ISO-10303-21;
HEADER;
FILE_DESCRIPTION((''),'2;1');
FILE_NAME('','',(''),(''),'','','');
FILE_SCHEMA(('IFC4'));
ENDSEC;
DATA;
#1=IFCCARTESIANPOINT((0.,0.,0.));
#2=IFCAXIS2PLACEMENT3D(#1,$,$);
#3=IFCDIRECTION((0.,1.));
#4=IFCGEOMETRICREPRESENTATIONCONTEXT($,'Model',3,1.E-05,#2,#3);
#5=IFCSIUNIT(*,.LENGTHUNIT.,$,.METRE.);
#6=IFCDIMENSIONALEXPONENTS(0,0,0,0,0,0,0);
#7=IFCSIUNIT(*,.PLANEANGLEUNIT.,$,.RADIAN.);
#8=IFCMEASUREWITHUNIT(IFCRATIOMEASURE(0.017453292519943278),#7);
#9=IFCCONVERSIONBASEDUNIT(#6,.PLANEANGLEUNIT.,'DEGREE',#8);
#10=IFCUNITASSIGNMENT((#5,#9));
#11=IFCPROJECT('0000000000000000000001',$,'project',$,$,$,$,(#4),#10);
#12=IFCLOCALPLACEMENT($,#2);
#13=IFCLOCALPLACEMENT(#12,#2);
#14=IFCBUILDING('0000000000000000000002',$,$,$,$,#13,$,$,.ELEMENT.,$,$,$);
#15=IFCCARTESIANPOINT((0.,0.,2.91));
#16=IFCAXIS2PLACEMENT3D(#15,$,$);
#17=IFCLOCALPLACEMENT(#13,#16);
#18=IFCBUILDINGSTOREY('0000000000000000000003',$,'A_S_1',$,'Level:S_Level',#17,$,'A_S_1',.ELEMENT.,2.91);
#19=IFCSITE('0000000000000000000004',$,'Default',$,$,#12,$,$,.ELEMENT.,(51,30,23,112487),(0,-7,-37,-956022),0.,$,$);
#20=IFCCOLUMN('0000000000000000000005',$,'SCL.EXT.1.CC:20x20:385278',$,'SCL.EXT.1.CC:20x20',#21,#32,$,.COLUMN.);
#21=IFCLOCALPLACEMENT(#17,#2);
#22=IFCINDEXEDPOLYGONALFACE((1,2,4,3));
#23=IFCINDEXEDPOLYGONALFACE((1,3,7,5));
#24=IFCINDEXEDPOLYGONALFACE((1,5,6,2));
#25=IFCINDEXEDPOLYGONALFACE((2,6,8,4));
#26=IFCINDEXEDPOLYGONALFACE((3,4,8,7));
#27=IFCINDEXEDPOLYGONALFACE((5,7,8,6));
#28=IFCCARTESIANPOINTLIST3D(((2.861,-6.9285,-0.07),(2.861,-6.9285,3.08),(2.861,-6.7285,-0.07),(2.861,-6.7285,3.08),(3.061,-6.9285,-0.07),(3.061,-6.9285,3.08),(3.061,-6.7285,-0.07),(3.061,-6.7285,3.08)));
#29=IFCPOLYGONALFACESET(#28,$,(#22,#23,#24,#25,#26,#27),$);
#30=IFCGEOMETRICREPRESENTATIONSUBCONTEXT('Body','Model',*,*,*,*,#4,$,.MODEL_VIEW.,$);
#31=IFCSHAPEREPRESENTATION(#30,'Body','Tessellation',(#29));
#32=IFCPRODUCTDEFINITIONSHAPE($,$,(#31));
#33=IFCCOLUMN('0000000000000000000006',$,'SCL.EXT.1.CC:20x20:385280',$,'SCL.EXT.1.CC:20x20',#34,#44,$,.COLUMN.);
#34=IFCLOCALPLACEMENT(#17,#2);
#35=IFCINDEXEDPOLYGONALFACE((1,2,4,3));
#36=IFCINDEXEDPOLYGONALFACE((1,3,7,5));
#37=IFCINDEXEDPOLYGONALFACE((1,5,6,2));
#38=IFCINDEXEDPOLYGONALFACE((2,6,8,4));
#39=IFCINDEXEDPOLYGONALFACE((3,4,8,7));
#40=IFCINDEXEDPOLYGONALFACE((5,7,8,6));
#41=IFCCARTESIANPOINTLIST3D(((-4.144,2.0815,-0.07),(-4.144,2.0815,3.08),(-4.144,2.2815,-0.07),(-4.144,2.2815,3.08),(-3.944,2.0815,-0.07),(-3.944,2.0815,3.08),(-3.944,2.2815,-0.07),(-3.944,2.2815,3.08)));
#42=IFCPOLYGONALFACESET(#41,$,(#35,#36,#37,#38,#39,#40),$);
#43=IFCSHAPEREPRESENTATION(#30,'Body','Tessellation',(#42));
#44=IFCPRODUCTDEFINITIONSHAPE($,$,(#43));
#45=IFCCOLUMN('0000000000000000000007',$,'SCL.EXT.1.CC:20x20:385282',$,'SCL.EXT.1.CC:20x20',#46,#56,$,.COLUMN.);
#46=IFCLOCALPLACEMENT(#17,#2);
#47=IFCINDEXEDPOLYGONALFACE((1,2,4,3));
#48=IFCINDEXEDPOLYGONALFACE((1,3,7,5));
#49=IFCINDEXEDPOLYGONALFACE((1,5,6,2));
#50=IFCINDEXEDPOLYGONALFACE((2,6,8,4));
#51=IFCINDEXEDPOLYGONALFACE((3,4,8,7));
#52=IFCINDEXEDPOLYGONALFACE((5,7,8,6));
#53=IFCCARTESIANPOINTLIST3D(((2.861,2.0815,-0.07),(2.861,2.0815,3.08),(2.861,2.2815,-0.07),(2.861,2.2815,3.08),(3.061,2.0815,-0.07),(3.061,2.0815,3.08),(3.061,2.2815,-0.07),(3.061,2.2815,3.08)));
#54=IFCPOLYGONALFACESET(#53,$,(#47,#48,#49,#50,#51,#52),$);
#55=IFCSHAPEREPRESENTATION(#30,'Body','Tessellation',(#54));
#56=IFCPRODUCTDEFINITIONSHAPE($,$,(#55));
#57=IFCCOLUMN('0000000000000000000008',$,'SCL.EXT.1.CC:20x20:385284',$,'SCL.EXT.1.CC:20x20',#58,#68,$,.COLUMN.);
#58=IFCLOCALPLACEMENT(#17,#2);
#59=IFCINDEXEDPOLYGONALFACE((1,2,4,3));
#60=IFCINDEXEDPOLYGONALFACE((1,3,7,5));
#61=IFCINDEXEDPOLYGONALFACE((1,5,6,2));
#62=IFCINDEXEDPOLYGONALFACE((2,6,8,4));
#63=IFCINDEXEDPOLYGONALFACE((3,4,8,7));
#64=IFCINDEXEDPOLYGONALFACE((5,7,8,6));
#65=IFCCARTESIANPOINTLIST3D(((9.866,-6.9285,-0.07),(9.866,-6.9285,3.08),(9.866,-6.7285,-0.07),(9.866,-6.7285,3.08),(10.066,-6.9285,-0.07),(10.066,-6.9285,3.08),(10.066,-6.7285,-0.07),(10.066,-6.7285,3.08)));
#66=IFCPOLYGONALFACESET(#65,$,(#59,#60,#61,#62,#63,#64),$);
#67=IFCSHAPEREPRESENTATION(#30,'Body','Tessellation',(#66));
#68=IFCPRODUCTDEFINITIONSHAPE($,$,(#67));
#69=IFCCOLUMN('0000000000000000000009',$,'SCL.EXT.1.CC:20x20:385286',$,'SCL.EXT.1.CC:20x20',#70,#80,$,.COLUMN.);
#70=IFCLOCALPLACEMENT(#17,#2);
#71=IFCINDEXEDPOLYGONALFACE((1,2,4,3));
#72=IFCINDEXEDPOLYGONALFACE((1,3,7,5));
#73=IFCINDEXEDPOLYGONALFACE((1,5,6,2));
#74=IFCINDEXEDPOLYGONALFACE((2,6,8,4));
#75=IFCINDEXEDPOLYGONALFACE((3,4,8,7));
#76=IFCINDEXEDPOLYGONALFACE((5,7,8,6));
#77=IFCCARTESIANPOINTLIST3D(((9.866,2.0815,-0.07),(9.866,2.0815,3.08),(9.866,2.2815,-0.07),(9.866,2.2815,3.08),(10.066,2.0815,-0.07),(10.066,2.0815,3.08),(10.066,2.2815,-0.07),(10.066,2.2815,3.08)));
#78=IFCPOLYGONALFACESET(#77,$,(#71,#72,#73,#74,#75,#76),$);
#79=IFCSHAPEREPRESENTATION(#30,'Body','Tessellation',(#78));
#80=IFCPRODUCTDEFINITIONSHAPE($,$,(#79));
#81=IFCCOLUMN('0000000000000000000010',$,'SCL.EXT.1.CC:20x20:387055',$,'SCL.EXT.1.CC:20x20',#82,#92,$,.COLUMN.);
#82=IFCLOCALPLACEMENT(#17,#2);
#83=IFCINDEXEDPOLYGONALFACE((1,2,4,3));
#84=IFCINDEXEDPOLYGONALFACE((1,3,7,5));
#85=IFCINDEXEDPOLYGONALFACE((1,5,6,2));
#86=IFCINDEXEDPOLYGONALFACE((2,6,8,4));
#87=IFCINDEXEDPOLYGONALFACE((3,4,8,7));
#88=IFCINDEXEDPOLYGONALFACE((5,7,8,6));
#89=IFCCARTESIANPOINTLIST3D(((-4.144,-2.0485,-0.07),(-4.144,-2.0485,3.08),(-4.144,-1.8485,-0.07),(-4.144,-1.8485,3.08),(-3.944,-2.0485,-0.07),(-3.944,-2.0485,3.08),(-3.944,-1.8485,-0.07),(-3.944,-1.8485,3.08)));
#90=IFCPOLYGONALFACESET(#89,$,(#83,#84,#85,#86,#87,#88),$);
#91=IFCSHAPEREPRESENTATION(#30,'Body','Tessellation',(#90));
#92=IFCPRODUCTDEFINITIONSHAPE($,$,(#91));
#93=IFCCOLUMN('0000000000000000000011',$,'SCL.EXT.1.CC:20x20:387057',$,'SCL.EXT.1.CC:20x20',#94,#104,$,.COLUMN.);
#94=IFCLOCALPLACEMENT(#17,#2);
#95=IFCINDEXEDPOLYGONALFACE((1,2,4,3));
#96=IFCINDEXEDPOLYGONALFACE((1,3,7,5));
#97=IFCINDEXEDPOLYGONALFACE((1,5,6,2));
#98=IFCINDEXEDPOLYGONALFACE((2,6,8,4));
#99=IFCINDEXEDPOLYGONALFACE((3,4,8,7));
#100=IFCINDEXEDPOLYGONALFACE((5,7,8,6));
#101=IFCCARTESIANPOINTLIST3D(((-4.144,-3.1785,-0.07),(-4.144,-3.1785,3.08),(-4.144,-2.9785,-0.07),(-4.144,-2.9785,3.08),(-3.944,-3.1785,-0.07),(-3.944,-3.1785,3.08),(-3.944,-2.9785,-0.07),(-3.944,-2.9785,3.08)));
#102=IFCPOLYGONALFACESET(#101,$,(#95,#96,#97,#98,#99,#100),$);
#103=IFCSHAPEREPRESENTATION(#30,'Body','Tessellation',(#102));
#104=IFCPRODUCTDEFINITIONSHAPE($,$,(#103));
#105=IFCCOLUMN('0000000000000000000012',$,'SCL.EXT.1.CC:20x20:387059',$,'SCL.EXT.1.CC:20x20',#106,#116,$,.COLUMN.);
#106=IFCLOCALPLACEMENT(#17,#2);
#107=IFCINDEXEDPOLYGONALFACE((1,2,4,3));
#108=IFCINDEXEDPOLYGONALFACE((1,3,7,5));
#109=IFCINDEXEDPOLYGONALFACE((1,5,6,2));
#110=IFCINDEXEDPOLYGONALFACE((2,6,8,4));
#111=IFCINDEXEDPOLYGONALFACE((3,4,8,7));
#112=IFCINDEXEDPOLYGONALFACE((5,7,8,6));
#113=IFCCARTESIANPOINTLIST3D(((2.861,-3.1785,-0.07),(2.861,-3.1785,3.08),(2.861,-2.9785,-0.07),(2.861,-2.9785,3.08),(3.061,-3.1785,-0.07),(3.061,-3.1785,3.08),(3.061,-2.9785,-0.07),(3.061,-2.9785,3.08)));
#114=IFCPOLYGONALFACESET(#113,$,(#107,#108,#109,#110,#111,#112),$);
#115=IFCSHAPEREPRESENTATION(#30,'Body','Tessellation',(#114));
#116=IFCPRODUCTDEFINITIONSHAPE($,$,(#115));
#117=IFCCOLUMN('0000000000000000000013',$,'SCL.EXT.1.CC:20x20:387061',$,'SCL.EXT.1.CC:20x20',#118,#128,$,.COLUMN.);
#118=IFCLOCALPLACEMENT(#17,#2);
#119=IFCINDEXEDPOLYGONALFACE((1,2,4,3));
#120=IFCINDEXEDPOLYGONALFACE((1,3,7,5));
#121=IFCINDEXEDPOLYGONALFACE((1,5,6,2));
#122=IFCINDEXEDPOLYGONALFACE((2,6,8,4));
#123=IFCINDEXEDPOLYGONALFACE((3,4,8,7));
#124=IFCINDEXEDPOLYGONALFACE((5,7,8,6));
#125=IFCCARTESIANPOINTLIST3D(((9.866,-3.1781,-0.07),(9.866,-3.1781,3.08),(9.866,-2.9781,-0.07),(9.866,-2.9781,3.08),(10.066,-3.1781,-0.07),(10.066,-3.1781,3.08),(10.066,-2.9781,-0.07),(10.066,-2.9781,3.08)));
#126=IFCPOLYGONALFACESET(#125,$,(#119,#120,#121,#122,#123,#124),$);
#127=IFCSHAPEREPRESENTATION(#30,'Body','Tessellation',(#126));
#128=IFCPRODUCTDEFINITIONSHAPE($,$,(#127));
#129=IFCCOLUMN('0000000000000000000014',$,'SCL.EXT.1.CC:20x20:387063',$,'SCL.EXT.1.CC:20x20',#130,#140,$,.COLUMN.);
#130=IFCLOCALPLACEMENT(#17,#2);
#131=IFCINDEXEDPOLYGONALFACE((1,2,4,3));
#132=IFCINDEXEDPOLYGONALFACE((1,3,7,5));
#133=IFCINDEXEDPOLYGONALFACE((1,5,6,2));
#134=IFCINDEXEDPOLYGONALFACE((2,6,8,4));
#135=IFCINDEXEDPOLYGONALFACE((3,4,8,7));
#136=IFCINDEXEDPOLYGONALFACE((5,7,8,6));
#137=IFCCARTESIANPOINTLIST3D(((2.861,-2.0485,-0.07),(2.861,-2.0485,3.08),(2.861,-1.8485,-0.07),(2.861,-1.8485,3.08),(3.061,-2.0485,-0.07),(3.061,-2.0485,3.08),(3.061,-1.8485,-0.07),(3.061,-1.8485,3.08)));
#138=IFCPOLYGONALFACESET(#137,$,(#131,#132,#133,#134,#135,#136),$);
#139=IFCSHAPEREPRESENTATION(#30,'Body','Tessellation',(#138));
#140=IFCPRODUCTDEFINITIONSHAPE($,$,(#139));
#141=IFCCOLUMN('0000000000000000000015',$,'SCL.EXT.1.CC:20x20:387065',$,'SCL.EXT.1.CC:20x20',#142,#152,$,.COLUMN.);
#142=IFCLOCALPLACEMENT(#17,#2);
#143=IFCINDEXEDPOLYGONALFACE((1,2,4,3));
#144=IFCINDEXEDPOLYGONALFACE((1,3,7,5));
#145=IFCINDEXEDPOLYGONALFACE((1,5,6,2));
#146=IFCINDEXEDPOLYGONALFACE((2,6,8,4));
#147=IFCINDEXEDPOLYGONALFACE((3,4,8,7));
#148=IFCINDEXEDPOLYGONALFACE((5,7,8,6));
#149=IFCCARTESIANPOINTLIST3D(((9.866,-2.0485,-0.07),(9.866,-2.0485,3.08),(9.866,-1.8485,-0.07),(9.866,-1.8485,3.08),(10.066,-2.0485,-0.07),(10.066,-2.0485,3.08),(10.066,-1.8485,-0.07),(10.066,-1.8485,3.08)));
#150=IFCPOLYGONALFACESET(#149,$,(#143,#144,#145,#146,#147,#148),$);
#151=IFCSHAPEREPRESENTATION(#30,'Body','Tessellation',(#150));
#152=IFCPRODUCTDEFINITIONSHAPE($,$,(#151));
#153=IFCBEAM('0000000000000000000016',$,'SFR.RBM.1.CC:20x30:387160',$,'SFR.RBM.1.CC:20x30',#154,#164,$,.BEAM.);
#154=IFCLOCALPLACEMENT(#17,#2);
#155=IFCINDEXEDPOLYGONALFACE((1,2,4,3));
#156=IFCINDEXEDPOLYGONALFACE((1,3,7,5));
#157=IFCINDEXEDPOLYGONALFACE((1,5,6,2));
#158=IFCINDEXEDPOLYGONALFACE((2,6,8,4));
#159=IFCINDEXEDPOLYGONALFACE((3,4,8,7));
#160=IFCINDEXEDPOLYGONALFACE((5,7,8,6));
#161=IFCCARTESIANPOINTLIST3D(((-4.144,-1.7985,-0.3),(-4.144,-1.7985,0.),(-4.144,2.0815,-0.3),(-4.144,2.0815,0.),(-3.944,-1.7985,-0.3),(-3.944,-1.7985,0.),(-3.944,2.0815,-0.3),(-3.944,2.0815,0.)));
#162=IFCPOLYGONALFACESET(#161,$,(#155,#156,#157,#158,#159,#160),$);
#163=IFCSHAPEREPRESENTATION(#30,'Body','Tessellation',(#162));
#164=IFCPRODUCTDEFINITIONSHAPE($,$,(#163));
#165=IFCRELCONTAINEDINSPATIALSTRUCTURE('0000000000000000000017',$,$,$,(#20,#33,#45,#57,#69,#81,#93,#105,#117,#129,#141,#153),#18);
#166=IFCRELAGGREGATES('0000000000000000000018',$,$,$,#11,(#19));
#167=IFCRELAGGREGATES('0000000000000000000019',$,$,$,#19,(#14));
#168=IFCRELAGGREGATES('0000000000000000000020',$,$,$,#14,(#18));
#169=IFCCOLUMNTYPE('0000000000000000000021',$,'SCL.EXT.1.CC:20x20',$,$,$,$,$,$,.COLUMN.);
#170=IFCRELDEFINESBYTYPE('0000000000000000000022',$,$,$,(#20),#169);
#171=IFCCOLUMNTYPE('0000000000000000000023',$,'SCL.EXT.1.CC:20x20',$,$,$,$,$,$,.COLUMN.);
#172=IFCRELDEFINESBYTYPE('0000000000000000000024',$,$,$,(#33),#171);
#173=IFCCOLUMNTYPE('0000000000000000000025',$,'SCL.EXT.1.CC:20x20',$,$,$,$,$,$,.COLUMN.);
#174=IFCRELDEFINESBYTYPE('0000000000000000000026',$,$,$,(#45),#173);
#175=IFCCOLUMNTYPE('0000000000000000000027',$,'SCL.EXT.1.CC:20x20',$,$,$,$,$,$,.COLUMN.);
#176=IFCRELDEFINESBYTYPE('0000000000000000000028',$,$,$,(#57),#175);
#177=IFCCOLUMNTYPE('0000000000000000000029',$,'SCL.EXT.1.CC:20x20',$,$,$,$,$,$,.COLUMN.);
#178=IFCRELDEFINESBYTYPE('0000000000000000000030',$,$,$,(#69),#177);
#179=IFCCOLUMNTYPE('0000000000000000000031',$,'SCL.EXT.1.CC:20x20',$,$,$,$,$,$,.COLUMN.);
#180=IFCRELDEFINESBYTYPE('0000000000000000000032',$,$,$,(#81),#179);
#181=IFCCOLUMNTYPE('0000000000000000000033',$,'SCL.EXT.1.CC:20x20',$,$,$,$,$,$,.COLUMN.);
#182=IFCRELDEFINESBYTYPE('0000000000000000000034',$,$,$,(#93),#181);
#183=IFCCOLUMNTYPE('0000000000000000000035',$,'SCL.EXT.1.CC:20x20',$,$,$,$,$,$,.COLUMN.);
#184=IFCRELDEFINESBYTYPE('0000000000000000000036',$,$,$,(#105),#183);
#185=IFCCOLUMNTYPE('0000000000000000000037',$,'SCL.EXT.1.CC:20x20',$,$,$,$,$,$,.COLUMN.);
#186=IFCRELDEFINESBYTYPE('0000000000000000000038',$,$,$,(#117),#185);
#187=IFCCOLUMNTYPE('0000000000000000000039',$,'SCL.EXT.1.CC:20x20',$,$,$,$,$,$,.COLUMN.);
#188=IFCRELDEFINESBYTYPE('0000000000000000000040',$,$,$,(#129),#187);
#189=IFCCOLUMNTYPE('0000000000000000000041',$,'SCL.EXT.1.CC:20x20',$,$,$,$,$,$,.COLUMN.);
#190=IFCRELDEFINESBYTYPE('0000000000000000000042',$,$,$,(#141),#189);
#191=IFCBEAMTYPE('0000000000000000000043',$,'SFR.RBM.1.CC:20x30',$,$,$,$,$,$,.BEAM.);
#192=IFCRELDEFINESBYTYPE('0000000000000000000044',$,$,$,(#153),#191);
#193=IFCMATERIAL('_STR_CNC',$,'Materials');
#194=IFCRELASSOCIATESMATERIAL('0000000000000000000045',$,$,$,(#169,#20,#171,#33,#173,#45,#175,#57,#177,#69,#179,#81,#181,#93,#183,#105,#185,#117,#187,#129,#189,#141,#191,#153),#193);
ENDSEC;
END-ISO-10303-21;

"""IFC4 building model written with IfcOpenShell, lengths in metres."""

from ifc_helpers import new_model, entity, si_unit, converted_unit, direction, frame, origin, place, context, subcontext, project, spatial, indexed_curve, outline, extrude, source, transform, mapped, material, type_object, type_shapes, element, save


model = new_model("IFC4")

# Units and contexts
model_context = context("Model", 3, precision=1e-05, world=origin(), true_north=direction((0.0, 1.0)))
body_context = subcontext(model_context, "Body", "Model", "MODEL_VIEW")
ifc_project = project(units=[si_unit("LENGTHUNIT", "METRE"), converted_unit("PLANEANGLEUNIT", "DEGREE", entity("IfcRatioMeasure", 0.017453292519943278), si_unit("PLANEANGLEUNIT", "RADIAN"), dimensions=[0, 0, 0, 0, 0, 0, 0])], contexts=[model_context])

# Site, building, storey
site_placement = place(None, origin())
site = spatial("IfcSite", under=ifc_project, at=site_placement, Name="Default", CompositionType="ELEMENT", RefLatitude=(51, 30, 23, 112487), RefLongitude=(0, -7, -37, -956022), RefElevation=0.0)
building_placement = place(site_placement, origin())
building = spatial("IfcBuilding", under=site, at=building_placement, CompositionType="ELEMENT")
storey_placement = place(building_placement, frame((0.0, 0.0, 2.91)))
storey = spatial("IfcBuildingStorey", under=building, at=storey_placement, Name="A_S_1", ObjectType="Level:S_Level", LongName="A_S_1", CompositionType="ELEMENT", Elevation=2.91)

# Columns
ifc_material_1 = material(Name="_STR_CNC", Category="Materials")
column_type_1 = type_object("IfcColumnType", Name="SCL.EXT.1.CC:20x20", PredefinedType="COLUMN", material=ifc_material_1)
shared_shape_1 = source(origin(), body_context, "Body", "SweptSolid", [
    extrude(outline(indexed_curve([(-0.1, -0.1), (0.1, -0.1), (0.1, 0.1), (-0.1, 0.1), (-0.1, -0.1)], self_intersect=False)), frame((2.961, -6.8285, 2.84), z_axis=(0.0, 0.0, 1.0), x_axis=(0.0, -1.0, 0.0)), (0.0, 0.0, 1.0), 3.15),
])
type_shapes(column_type_1, [shared_shape_1])
column_1_placement = place(storey_placement, frame((0.0, 0.0, -2.91)))
element("IfcColumn", 1, at=column_1_placement, inside=storey, type_object=column_type_1, material=ifc_material_1, Name="SCL.EXT.1.CC:20x20:385278", ObjectType="SCL.EXT.1.CC:20x20", PredefinedType="COLUMN", context=body_context, shape_type="MappedRepresentation", body=[
    mapped(shared_shape_1, transform((0.0, 0.0, 0.0), scale=1.0)),
])
column_type_2 = type_object("IfcColumnType", Name="SCL.EXT.1.CC:20x20", PredefinedType="COLUMN", material=ifc_material_1)
shared_shape_2 = source(origin(), body_context, "Body", "SweptSolid", [
    extrude(outline(indexed_curve([(-0.1, -0.1), (0.1, -0.1), (0.1, 0.1), (-0.1, 0.1), (-0.1, -0.1)], self_intersect=False)), frame((-4.044, 2.1815, 2.84), z_axis=(0.0, 0.0, 1.0), x_axis=(0.0, -1.0, 0.0)), (0.0, 0.0, 1.0), 3.15),
])
type_shapes(column_type_2, [shared_shape_2])
column_2_placement = place(storey_placement, frame((0.0, 0.0, -2.91)))
element("IfcColumn", 2, at=column_2_placement, inside=storey, type_object=column_type_2, material=ifc_material_1, Name="SCL.EXT.1.CC:20x20:385280", ObjectType="SCL.EXT.1.CC:20x20", PredefinedType="COLUMN", context=body_context, shape_type="MappedRepresentation", body=[
    mapped(shared_shape_2, transform((0.0, 0.0, 0.0), scale=1.0)),
])
column_type_3 = type_object("IfcColumnType", Name="SCL.EXT.1.CC:20x20", PredefinedType="COLUMN", material=ifc_material_1)
shared_shape_3 = source(origin(), body_context, "Body", "SweptSolid", [
    extrude(outline(indexed_curve([(-0.1, -0.1), (0.1, -0.1), (0.1, 0.1), (-0.1, 0.1), (-0.1, -0.1)], self_intersect=False)), frame((2.961, 2.1815, 2.84), z_axis=(0.0, 0.0, 1.0), x_axis=(0.0, -1.0, 0.0)), (0.0, 0.0, 1.0), 3.15),
])
type_shapes(column_type_3, [shared_shape_3])
column_3_placement = place(storey_placement, frame((0.0, 0.0, -2.91)))
element("IfcColumn", 3, at=column_3_placement, inside=storey, type_object=column_type_3, material=ifc_material_1, Name="SCL.EXT.1.CC:20x20:385282", ObjectType="SCL.EXT.1.CC:20x20", PredefinedType="COLUMN", context=body_context, shape_type="MappedRepresentation", body=[
    mapped(shared_shape_3, transform((0.0, 0.0, 0.0), scale=1.0)),
])
column_type_4 = type_object("IfcColumnType", Name="SCL.EXT.1.CC:20x20", PredefinedType="COLUMN", material=ifc_material_1)
shared_shape_4 = source(origin(), body_context, "Body", "SweptSolid", [
    extrude(outline(indexed_curve([(-0.1, -0.1), (0.1, -0.1), (0.1, 0.1), (-0.1, 0.1), (-0.1, -0.1)], self_intersect=False)), frame((9.966, -6.8285, 2.84), z_axis=(0.0, 0.0, 1.0), x_axis=(0.0, -1.0, 0.0)), (0.0, 0.0, 1.0), 3.15),
])
type_shapes(column_type_4, [shared_shape_4])
column_4_placement = place(storey_placement, frame((0.0, 0.0, -2.91)))
element("IfcColumn", 4, at=column_4_placement, inside=storey, type_object=column_type_4, material=ifc_material_1, Name="SCL.EXT.1.CC:20x20:385284", ObjectType="SCL.EXT.1.CC:20x20", PredefinedType="COLUMN", context=body_context, shape_type="MappedRepresentation", body=[
    mapped(shared_shape_4, transform((0.0, 0.0, 0.0), scale=1.0)),
])
column_type_5 = type_object("IfcColumnType", Name="SCL.EXT.1.CC:20x20", PredefinedType="COLUMN", material=ifc_material_1)
shared_shape_5 = source(origin(), body_context, "Body", "SweptSolid", [
    extrude(outline(indexed_curve([(-0.1, -0.1), (0.1, -0.1), (0.1, 0.1), (-0.1, 0.1), (-0.1, -0.1)], self_intersect=False)), frame((9.966, 2.1815, 2.84), z_axis=(0.0, 0.0, 1.0), x_axis=(0.0, -1.0, 0.0)), (0.0, 0.0, 1.0), 3.15),
])
type_shapes(column_type_5, [shared_shape_5])
column_5_placement = place(storey_placement, frame((0.0, 0.0, -2.91)))
element("IfcColumn", 5, at=column_5_placement, inside=storey, type_object=column_type_5, material=ifc_material_1, Name="SCL.EXT.1.CC:20x20:385286", ObjectType="SCL.EXT.1.CC:20x20", PredefinedType="COLUMN", context=body_context, shape_type="MappedRepresentation", body=[
    mapped(shared_shape_5, transform((0.0, 0.0, 0.0), scale=1.0)),
])
column_type_6 = type_object("IfcColumnType", Name="SCL.EXT.1.CC:20x20", PredefinedType="COLUMN", material=ifc_material_1)
shared_shape_6 = source(origin(), body_context, "Body", "SweptSolid", [
    extrude(outline(indexed_curve([(-0.1, -0.1), (0.1, -0.1), (0.1, 0.1), (-0.1, 0.1), (-0.1, -0.1)], self_intersect=False)), frame((-4.044, -1.9485, 2.84), z_axis=(0.0, 0.0, 1.0), x_axis=(0.0, -1.0, 0.0)), (0.0, 0.0, 1.0), 3.15),
])
type_shapes(column_type_6, [shared_shape_6])
column_6_placement = place(storey_placement, frame((0.0, 0.0, -2.91)))
element("IfcColumn", 6, at=column_6_placement, inside=storey, type_object=column_type_6, material=ifc_material_1, Name="SCL.EXT.1.CC:20x20:387055", ObjectType="SCL.EXT.1.CC:20x20", PredefinedType="COLUMN", context=body_context, shape_type="MappedRepresentation", body=[
    mapped(shared_shape_6, transform((0.0, 0.0, 0.0), scale=1.0)),
])
column_type_7 = type_object("IfcColumnType", Name="SCL.EXT.1.CC:20x20", PredefinedType="COLUMN", material=ifc_material_1)
shared_shape_7 = source(origin(), body_context, "Body", "SweptSolid", [
    extrude(outline(indexed_curve([(-0.1, -0.1), (0.1, -0.1), (0.1, 0.1), (-0.1, 0.1), (-0.1, -0.1)], self_intersect=False)), frame((-4.044, -3.0785, 2.84), z_axis=(0.0, 0.0, 1.0), x_axis=(0.0, -1.0, 0.0)), (0.0, 0.0, 1.0), 3.15),
])
type_shapes(column_type_7, [shared_shape_7])
column_7_placement = place(storey_placement, frame((0.0, 0.0, -2.91)))
element("IfcColumn", 7, at=column_7_placement, inside=storey, type_object=column_type_7, material=ifc_material_1, Name="SCL.EXT.1.CC:20x20:387057", ObjectType="SCL.EXT.1.CC:20x20", PredefinedType="COLUMN", context=body_context, shape_type="MappedRepresentation", body=[
    mapped(shared_shape_7, transform((0.0, 0.0, 0.0), scale=1.0)),
])
column_type_8 = type_object("IfcColumnType", Name="SCL.EXT.1.CC:20x20", PredefinedType="COLUMN", material=ifc_material_1)
shared_shape_8 = source(origin(), body_context, "Body", "SweptSolid", [
    extrude(outline(indexed_curve([(-0.1, -0.1), (0.1, -0.1), (0.1, 0.1), (-0.1, 0.1), (-0.1, -0.1)], self_intersect=False)), frame((2.961, -3.0785, 2.84), z_axis=(0.0, 0.0, 1.0), x_axis=(0.0, -1.0, 0.0)), (0.0, 0.0, 1.0), 3.15),
])
type_shapes(column_type_8, [shared_shape_8])
column_8_placement = place(storey_placement, frame((0.0, 0.0, -2.91)))
element("IfcColumn", 8, at=column_8_placement, inside=storey, type_object=column_type_8, material=ifc_material_1, Name="SCL.EXT.1.CC:20x20:387059", ObjectType="SCL.EXT.1.CC:20x20", PredefinedType="COLUMN", context=body_context, shape_type="MappedRepresentation", body=[
    mapped(shared_shape_8, transform((0.0, 0.0, 0.0), scale=1.0)),
])
column_type_9 = type_object("IfcColumnType", Name="SCL.EXT.1.CC:20x20", PredefinedType="COLUMN", material=ifc_material_1)
shared_shape_9 = source(origin(), body_context, "Body", "SweptSolid", [
    extrude(outline(indexed_curve([(-0.1, -0.1), (0.1, -0.1), (0.1, 0.1), (-0.1, 0.1), (-0.1, -0.1)], self_intersect=False)), frame((9.966, -3.0781, 2.84), z_axis=(0.0, 0.0, 1.0), x_axis=(0.0, -1.0, 0.0)), (0.0, 0.0, 1.0), 3.15),
])
type_shapes(column_type_9, [shared_shape_9])
column_9_placement = place(storey_placement, frame((0.0, 0.0, -2.91)))
element("IfcColumn", 9, at=column_9_placement, inside=storey, type_object=column_type_9, material=ifc_material_1, Name="SCL.EXT.1.CC:20x20:387061", ObjectType="SCL.EXT.1.CC:20x20", PredefinedType="COLUMN", context=body_context, shape_type="MappedRepresentation", body=[
    mapped(shared_shape_9, transform((0.0, 0.0, 0.0), scale=1.0)),
])
column_type_10 = type_object("IfcColumnType", Name="SCL.EXT.1.CC:20x20", PredefinedType="COLUMN", material=ifc_material_1)
shared_shape_10 = source(origin(), body_context, "Body", "SweptSolid", [
    extrude(outline(indexed_curve([(-0.1, -0.1), (0.1, -0.1), (0.1, 0.1), (-0.1, 0.1), (-0.1, -0.1)], self_intersect=False)), frame((2.961, -1.9485, 2.84), z_axis=(0.0, 0.0, 1.0), x_axis=(0.0, -1.0, 0.0)), (0.0, 0.0, 1.0), 3.15),
])
type_shapes(column_type_10, [shared_shape_10])
column_10_placement = place(storey_placement, frame((0.0, 0.0, -2.91)))
element("IfcColumn", 10, at=column_10_placement, inside=storey, type_object=column_type_10, material=ifc_material_1, Name="SCL.EXT.1.CC:20x20:387063", ObjectType="SCL.EXT.1.CC:20x20", PredefinedType="COLUMN", context=body_context, shape_type="MappedRepresentation", body=[
    mapped(shared_shape_10, transform((0.0, 0.0, 0.0), scale=1.0)),
])
column_type_11 = type_object("IfcColumnType", Name="SCL.EXT.1.CC:20x20", PredefinedType="COLUMN", material=ifc_material_1)
shared_shape_11 = source(origin(), body_context, "Body", "SweptSolid", [
    extrude(outline(indexed_curve([(-0.1, -0.1), (0.1, -0.1), (0.1, 0.1), (-0.1, 0.1), (-0.1, -0.1)], self_intersect=False)), frame((9.966, -1.9485, 2.84), z_axis=(0.0, 0.0, 1.0), x_axis=(0.0, -1.0, 0.0)), (0.0, 0.0, 1.0), 3.15),
])
type_shapes(column_type_11, [shared_shape_11])
column_11_placement = place(storey_placement, frame((0.0, 0.0, -2.91)))
element("IfcColumn", 11, at=column_11_placement, inside=storey, type_object=column_type_11, material=ifc_material_1, Name="SCL.EXT.1.CC:20x20:387065", ObjectType="SCL.EXT.1.CC:20x20", PredefinedType="COLUMN", context=body_context, shape_type="MappedRepresentation", body=[
    mapped(shared_shape_11, transform((0.0, 0.0, 0.0), scale=1.0)),
])

# Beam
beam_type_1 = type_object("IfcBeamType", Name="SFR.RBM.1.CC:20x30", PredefinedType="BEAM", material=ifc_material_1)
shared_shape_12 = source(origin(), body_context, "Body", "SweptSolid", [
    extrude(outline(indexed_curve([(-0.1, -0.15), (0.1, -0.15), (0.1, 0.15), (-0.1, 0.15), (-0.1, -0.15)], self_intersect=False)), frame((-4.044, 2.0815, 2.76), z_axis=(0.0, -1.0, 0.0), x_axis=(-1.0, 0.0, 0.0)), (0.0, 0.0, 1.0), 3.88),
])
type_shapes(beam_type_1, [shared_shape_12])
beam_1_placement = place(storey_placement, frame((0.0, 0.0, -2.91)))
element("IfcBeam", 12, at=beam_1_placement, inside=storey, type_object=beam_type_1, material=ifc_material_1, Name="SFR.RBM.1.CC:20x30:387160", ObjectType="SFR.RBM.1.CC:20x30", PredefinedType="BEAM", context=body_context, shape_type="MappedRepresentation", body=[
    mapped(shared_shape_12, transform((0.0, 0.0, 0.0), scale=1.0)),
])

save(model, "model.ifc")
